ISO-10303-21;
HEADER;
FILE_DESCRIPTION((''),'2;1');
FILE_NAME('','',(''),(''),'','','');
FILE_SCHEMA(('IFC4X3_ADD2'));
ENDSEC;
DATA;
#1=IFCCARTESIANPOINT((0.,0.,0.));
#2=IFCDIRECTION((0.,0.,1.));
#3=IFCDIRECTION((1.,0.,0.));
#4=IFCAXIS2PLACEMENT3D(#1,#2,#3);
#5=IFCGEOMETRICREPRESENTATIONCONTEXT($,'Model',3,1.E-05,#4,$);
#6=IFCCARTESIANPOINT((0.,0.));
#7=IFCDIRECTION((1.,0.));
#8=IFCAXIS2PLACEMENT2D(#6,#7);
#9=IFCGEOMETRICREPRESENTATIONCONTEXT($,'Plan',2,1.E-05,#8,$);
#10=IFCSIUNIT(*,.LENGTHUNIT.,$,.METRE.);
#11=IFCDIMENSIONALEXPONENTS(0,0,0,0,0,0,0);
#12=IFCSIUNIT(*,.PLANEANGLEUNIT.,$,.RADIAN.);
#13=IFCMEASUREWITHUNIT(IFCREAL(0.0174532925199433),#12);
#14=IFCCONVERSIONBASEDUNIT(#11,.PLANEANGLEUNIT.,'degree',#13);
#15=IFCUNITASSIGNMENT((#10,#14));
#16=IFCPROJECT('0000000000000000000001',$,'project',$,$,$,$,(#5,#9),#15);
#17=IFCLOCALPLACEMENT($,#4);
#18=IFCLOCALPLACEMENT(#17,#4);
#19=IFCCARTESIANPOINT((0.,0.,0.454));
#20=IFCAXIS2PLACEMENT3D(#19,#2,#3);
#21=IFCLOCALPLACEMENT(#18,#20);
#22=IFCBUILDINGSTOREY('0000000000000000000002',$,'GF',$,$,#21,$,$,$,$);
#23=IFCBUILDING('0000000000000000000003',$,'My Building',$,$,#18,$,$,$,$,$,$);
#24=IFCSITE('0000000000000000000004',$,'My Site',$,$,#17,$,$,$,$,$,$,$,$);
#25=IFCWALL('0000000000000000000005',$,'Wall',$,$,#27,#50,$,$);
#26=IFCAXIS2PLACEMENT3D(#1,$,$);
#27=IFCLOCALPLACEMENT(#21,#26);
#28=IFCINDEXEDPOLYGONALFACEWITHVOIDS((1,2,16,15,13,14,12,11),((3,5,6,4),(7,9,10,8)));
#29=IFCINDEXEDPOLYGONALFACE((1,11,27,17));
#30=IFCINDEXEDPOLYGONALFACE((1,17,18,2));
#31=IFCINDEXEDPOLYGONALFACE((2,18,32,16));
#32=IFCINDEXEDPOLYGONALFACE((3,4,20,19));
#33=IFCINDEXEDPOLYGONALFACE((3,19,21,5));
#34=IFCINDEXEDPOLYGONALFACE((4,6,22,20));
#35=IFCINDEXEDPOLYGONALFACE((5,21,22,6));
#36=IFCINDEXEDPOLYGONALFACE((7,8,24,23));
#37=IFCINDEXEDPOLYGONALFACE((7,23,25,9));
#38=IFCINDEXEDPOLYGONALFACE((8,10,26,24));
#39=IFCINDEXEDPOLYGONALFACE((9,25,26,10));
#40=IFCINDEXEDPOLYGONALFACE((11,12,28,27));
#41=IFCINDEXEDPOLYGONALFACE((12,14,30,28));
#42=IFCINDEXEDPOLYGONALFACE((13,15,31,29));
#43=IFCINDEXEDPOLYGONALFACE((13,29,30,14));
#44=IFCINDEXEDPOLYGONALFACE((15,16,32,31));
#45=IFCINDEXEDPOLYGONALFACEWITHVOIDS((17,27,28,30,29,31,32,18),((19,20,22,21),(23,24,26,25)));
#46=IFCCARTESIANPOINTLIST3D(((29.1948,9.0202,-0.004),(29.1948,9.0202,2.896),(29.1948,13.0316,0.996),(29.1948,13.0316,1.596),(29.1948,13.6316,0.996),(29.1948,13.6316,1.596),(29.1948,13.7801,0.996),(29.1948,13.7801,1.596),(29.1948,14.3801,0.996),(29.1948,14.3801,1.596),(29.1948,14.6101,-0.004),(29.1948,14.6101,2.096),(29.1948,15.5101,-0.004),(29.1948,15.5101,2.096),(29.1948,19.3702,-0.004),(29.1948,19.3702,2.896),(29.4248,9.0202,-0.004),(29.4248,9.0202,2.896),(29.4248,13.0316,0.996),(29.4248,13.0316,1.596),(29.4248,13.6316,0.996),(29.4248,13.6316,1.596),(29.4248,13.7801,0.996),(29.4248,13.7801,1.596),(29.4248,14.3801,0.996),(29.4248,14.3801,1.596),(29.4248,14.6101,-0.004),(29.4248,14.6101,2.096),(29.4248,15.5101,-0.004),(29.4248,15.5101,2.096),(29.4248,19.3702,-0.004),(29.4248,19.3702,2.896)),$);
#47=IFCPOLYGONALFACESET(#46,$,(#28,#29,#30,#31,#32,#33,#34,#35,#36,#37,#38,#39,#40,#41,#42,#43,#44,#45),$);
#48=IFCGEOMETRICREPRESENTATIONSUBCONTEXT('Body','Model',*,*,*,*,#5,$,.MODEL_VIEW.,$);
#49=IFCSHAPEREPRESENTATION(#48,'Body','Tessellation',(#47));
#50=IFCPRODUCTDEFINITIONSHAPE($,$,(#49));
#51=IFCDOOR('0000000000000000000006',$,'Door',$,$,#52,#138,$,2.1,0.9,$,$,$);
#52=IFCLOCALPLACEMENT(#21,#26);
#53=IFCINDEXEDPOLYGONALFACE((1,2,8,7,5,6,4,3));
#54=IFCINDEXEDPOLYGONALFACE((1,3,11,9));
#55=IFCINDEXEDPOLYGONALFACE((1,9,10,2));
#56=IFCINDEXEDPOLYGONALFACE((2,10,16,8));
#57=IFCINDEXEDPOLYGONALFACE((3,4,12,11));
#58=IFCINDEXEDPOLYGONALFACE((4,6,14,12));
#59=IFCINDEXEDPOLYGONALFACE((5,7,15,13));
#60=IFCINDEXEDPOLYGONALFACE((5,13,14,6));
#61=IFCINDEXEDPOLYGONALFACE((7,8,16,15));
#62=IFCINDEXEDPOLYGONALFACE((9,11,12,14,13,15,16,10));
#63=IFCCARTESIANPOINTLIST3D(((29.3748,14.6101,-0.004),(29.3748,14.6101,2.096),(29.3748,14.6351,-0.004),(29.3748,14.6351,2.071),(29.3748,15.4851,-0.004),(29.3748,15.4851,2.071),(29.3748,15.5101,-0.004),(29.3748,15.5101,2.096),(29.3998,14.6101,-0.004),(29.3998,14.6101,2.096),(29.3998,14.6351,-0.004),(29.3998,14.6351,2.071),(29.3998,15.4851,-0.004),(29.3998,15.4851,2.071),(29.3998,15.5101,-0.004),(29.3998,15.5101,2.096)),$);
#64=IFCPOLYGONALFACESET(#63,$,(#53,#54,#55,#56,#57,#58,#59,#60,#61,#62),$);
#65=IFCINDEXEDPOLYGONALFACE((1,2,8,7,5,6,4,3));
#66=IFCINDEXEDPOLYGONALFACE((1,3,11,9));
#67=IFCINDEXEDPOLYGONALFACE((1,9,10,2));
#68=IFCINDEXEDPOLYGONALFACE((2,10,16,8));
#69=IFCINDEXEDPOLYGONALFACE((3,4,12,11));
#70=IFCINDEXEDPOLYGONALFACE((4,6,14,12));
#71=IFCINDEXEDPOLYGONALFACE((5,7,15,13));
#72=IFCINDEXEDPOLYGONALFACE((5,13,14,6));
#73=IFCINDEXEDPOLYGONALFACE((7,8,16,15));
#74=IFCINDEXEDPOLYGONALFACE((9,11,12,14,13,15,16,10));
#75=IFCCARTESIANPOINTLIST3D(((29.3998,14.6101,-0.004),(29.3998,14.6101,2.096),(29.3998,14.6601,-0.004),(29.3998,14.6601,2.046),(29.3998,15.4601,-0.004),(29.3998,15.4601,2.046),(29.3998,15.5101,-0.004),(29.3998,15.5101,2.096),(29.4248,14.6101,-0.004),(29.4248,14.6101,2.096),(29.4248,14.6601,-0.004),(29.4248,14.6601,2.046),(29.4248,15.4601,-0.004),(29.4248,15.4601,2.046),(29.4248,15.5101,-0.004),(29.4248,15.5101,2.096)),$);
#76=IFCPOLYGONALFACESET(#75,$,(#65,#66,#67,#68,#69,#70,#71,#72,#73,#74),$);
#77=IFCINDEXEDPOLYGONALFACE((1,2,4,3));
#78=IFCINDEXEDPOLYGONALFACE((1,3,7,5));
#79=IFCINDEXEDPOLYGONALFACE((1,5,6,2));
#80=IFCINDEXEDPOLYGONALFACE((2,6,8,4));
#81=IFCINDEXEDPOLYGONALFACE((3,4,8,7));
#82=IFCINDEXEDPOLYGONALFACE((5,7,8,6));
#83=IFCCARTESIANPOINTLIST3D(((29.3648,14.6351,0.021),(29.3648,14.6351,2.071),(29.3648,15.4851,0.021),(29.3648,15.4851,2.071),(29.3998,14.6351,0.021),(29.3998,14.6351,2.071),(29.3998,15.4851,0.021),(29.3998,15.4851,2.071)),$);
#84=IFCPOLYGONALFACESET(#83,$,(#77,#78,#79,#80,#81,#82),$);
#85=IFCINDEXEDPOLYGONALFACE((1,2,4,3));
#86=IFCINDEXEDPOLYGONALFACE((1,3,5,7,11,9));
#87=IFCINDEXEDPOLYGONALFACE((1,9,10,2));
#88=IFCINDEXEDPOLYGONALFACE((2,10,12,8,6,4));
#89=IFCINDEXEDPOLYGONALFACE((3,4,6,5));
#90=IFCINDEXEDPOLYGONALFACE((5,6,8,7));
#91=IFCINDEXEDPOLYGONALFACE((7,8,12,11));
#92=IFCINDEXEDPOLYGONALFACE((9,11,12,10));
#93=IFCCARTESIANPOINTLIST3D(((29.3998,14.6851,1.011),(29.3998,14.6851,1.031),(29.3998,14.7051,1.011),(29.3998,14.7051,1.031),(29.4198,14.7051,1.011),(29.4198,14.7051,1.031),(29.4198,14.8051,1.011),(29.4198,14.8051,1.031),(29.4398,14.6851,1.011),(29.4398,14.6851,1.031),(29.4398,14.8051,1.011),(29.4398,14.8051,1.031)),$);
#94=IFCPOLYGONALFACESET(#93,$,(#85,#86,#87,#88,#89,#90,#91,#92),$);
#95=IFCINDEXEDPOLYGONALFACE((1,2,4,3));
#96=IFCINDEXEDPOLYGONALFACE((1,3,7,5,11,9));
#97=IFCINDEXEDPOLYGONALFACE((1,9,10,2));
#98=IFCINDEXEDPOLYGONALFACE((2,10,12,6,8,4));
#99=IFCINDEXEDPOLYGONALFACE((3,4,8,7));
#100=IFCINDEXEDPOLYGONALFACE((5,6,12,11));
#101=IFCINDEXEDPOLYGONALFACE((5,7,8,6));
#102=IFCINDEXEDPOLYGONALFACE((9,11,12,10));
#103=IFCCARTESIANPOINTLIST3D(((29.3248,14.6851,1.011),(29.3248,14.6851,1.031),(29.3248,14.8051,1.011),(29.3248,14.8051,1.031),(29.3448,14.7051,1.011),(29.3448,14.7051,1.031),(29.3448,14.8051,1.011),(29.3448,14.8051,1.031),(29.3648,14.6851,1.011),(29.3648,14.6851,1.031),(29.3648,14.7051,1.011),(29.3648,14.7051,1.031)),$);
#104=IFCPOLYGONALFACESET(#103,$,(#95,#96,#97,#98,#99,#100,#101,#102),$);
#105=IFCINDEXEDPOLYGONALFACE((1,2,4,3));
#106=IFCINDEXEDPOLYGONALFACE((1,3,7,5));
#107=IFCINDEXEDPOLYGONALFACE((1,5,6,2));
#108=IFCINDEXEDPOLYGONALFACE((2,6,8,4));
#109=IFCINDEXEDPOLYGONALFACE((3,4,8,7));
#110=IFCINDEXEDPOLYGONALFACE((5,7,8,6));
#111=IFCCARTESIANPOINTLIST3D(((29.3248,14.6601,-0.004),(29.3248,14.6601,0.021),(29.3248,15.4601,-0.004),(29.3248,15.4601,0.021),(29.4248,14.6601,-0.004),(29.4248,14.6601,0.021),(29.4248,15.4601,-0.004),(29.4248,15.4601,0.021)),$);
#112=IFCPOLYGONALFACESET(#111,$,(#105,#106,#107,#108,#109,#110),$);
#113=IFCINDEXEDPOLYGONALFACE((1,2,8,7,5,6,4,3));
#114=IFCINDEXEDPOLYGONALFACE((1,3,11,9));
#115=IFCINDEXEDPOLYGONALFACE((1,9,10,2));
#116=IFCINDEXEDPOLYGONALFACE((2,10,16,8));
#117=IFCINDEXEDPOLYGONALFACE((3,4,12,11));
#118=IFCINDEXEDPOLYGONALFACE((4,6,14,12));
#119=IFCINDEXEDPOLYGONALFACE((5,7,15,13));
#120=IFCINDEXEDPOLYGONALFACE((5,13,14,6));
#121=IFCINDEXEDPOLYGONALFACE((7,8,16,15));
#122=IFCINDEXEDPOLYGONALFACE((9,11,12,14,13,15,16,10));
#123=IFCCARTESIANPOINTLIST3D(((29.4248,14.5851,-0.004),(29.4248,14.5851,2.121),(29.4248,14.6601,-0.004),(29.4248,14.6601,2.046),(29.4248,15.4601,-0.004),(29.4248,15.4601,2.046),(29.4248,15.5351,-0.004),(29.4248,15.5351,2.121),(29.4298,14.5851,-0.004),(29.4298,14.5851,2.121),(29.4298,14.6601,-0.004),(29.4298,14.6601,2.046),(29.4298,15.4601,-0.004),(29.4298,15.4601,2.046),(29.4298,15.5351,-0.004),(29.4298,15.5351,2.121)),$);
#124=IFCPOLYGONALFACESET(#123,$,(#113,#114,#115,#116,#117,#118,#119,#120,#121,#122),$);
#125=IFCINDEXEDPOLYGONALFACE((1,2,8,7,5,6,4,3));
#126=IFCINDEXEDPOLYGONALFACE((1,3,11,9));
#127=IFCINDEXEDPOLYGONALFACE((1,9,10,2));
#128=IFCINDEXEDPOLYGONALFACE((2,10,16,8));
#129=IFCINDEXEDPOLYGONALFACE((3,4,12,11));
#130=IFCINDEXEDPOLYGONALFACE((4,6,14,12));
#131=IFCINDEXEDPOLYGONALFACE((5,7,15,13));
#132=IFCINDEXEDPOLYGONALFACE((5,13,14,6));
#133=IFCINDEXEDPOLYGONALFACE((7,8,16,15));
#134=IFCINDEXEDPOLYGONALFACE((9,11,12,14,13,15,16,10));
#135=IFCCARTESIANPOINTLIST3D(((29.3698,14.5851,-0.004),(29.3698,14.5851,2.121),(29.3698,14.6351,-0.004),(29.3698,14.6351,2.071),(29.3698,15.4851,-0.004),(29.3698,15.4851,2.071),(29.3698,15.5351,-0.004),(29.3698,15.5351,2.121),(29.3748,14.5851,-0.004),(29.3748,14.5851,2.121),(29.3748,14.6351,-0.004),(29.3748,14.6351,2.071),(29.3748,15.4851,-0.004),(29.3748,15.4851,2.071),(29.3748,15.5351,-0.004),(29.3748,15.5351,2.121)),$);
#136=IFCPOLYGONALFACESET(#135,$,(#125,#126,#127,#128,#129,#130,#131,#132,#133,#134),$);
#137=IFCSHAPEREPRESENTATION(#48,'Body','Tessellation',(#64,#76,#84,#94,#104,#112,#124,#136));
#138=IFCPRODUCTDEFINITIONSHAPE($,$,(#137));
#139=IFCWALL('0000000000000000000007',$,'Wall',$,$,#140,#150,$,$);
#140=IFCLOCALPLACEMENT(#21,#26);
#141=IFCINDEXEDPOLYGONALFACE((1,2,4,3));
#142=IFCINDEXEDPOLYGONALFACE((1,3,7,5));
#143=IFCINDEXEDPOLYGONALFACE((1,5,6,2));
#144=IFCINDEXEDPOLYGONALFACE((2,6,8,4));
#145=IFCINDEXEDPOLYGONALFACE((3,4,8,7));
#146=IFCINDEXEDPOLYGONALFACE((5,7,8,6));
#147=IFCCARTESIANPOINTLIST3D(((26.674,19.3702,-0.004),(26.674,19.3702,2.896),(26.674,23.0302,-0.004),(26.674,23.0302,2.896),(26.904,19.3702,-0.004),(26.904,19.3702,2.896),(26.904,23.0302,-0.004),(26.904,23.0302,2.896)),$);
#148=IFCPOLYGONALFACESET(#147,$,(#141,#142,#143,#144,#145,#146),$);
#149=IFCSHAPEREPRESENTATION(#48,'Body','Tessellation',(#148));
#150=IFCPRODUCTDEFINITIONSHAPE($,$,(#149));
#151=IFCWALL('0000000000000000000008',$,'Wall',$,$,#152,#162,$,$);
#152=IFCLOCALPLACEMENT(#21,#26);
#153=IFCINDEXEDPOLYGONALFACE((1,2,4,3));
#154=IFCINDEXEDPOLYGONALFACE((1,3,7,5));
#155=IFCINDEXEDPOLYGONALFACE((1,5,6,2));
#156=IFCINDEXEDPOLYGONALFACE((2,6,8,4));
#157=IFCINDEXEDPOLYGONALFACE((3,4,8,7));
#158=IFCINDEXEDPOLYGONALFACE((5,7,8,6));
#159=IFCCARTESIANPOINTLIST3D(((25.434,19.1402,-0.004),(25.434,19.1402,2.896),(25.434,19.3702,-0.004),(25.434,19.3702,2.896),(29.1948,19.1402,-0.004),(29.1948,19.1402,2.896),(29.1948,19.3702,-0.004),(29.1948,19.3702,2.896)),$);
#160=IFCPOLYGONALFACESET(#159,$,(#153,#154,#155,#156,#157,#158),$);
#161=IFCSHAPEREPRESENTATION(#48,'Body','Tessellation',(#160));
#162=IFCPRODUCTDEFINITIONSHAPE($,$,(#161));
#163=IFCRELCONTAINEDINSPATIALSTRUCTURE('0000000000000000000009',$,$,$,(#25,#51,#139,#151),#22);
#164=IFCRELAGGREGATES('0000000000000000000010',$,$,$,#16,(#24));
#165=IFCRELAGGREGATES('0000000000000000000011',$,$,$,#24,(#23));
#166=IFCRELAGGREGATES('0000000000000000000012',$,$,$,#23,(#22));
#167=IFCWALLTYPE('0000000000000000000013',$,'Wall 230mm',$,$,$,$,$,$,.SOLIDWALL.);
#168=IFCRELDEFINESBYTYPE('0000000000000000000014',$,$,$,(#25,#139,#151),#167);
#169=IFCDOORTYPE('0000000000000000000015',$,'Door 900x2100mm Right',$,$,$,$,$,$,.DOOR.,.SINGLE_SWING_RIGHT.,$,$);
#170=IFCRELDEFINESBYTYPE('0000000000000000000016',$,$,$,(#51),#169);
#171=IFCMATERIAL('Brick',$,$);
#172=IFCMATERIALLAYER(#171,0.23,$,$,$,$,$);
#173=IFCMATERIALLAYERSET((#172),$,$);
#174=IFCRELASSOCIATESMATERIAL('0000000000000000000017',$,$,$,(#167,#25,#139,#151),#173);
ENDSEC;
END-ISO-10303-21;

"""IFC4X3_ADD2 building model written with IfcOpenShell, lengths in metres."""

from ifc_helpers import new_model, entity, si_unit, converted_unit, frame, origin_with_axes, origin_2d_with_axis, place, context, subcontext, project, spatial, line, indexed_curve, outline, extrude, shape, source, transform, mapped, material, layer, layer_set, layer_usage, type_object, type_shapes, element, fill, save


model = new_model("IFC4X3_ADD2")

# Units and contexts
model_context = context("Model", 3, precision=1e-05, world=origin_with_axes())
plan_context = context("Plan", 2, precision=1e-05, world=origin_2d_with_axis())
body_context_1 = subcontext(model_context, "Body", "Model", "MODEL_VIEW")
body_context_2 = subcontext(plan_context, "Body", "Plan", "PLAN_VIEW")
ifc_project = project(units=[si_unit("LENGTHUNIT", "METRE"), converted_unit("PLANEANGLEUNIT", "degree", entity("IfcReal", 0.0174532925199433), si_unit("PLANEANGLEUNIT", "RADIAN"), dimensions=[0, 0, 0, 0, 0, 0, 0])], contexts=[model_context, plan_context])

# Site, building, storey
site_placement = place(None, origin_with_axes())
site = spatial("IfcSite", under=ifc_project, at=site_placement, Name="My Site")
building_placement = place(site_placement, origin_with_axes())
building = spatial("IfcBuilding", under=site, at=building_placement, Name="My Building")
storey_placement = place(building_placement, frame((0.0, 0.0, 0.454), z_axis=(0.0, 0.0, 1.0), x_axis=(1.0, 0.0, 0.0)))
storey = spatial("IfcBuildingStorey", under=building, at=storey_placement, Name="GF")

# Shared definitions
ifc_material_1 = material(Name="Brick")

# Shared definitions
ifc_layer_1 = layer(ifc_material_1, 0.23)
ifc_layer_set_1 = layer_set([ifc_layer_1])
wall_type_1 = type_object("IfcWallType", Name="Wall 230mm", PredefinedType="SOLIDWALL", material=ifc_layer_set_1)

# Wall, openings, door
ifc_layer_usage_1 = layer_usage(ifc_layer_set_1, "AXIS2", "POSITIVE", 0.0)
wall_1_placement = place(storey_placement, frame((29.4248, 9.0202, -0.004), z_axis=(0.0, 0.0, 1.0), x_axis=(0.000001, 1.0, 0.0)))
wall_1 = element("IfcWall", 1, at=wall_1_placement, inside=storey, type_object=wall_type_1, material=ifc_layer_usage_1, Name="Wall", context=body_context_1, shape_type="SweptSolid", body=[
    extrude(outline(indexed_curve([(0.0, 0.0), (0.0, 0.23), (10.35, 0.23), (10.35, 0.0), (0.0, 0.0)], self_intersect=False)), origin_with_axes(), (0.0, 0.0, 1.0), 2.9),
])
shared_shape_1 = source(origin_with_axes(), body_context_1, "Body", "SweptSolid", [
    extrude(outline(indexed_curve([(0.0, 0.0), (0.9, 0.0), (0.9, 2.1), (0.0, 2.1)], segments=[line(1, 2, 3, 4, 1)])), frame((0.0, -0.6, 0.0), z_axis=(0.0, -1.0, 0.0), x_axis=(1.0, 0.0, 0.0)), (0.0, 0.0, -1.0), 1.2),
])
opening_1_placement = place(wall_1_placement, frame((5.5899, 0.0, 0.0), z_axis=(0.0, 0.0, 1.0), x_axis=(1.0, 0.0, 0.0)))
opening_1 = element("IfcOpeningElement", 2, at=opening_1_placement, cuts=wall_1, PredefinedType="OPENING", context=body_context_1, shape_type="MappedRepresentation", body=[
    mapped(shared_shape_1, transform((0.0, 0.0, 0.0), x_axis=(1.0, 0.0, 0.0), y_axis=(0.0, 1.0, 0.0), z_axis=(0.0, 0.0, 1.0), scale=1.0)),
])
shared_shape_2 = source(origin_with_axes(), body_context_1, "Body", "SweptSolid", [
    extrude(outline(indexed_curve([(0.0, 0.0), (0.6, 0.0), (0.6, 0.6), (0.0, 0.6)], segments=[line(1, 2, 3, 4, 1)])), frame((-0.3, -0.6, 0.0), z_axis=(0.0, -1.0, 0.0), x_axis=(1.0, 0.0, 0.0)), (0.0, 0.0, -1.0), 1.2),
])
opening_2_placement = place(wall_1_placement, frame((5.0599, 0.0, 1.0), z_axis=(0.0, 0.0, 1.0), x_axis=(1.0, 0.0, 0.0)))
element("IfcOpeningElement", 3, at=opening_2_placement, cuts=wall_1, PredefinedType="OPENING", context=body_context_1, shape_type="MappedRepresentation", body=[
    mapped(shared_shape_2, transform((0.0, 0.0, 0.0), x_axis=(1.0, 0.0, 0.0), y_axis=(0.0, 1.0, 0.0), z_axis=(0.0, 0.0, 1.0), scale=1.0)),
])
opening_3_placement = place(wall_1_placement, frame((4.3114, 0.0, 1.0), z_axis=(0.0, 0.0, 1.0), x_axis=(1.0, 0.0, 0.0)))
element("IfcOpeningElement", 4, at=opening_3_placement, cuts=wall_1, PredefinedType="OPENING", context=body_context_1, shape_type="MappedRepresentation", body=[
    mapped(shared_shape_2, transform((0.0, 0.0, 0.0), x_axis=(1.0, 0.0, 0.0), y_axis=(0.0, 1.0, 0.0), z_axis=(0.0, 0.0, 1.0), scale=1.0)),
])
door_type_1 = type_object("IfcDoorType", Name="Door 900x2100mm Right", OperationType="SINGLE_SWING_RIGHT", PredefinedType="DOOR")
shared_shape_3 = source(origin_with_axes(), body_context_1, "Body", "SweptSolid", [
    extrude(outline(indexed_curve([(0.0, 0.0), (0.0, 2.1), (0.9, 2.1), (0.9, 0.0), (0.875, 0.0), (0.875, 2.075), (0.025, 2.075), (0.025, 0.0)], segments=[line(1, 2, 3, 4, 5, 6, 7, 8, 1)])), frame((0.0, 0.025, 0.0), z_axis=(0.0, -1.0, 0.0), x_axis=(1.0, 0.0, 0.0)), (0.0, 0.0, -1.0), 0.025),
    extrude(outline(indexed_curve([(0.0, 0.0), (0.0, 2.1), (0.9, 2.1), (0.9, 0.0), (0.85, 0.0), (0.85, 2.05), (0.05, 2.05), (0.05, 0.0)], segments=[line(1, 2, 3, 4, 5, 6, 7, 8, 1)])), frame((0.0, 0.0, 0.0), z_axis=(0.0, -1.0, 0.0), x_axis=(1.0, 0.0, 0.0)), (0.0, 0.0, -1.0), 0.025),
    extrude(outline(indexed_curve([(0.0, 0.0), (0.85, 0.0), (0.85, 0.035), (0.0, 0.035)], segments=[line(1, 2, 3, 4, 1)])), frame((0.025, 0.025, 0.025), z_axis=(0.0, 0.0, 1.0), x_axis=(1.0, 0.0, 0.0)), (0.0, 0.0, 1.0), 2.05),
    extrude(outline(indexed_curve([(0.0, 0.0), (0.0, -0.04), (0.12, -0.04), (0.12, -0.02), (0.02, -0.02), (0.02, 0.0)], segments=[line(1, 2, 3, 4, 5, 6, 1)])), frame((0.075, 0.025, 1.015), z_axis=(0.0, 0.0, 1.0), x_axis=(1.0, 0.0, 0.0)), (0.0, 0.0, 1.0), 0.02),
    extrude(outline(indexed_curve([(0.0, 0.0), (0.0, 0.04), (0.12, 0.04), (0.12, 0.02), (0.02, 0.02), (0.02, 0.0)], segments=[line(1, 2, 3, 4, 5, 6, 1)])), frame((0.075, 0.06, 1.015), z_axis=(0.0, 0.0, 1.0), x_axis=(1.0, 0.0, 0.0)), (0.0, 0.0, 1.0), 0.02),
    extrude(outline(indexed_curve([(0.0, 0.0), (0.8, 0.0), (0.8, 0.1), (0.0, 0.1)], segments=[line(1, 2, 3, 4, 1)])), frame((0.05, 0.0, 0.0), z_axis=(0.0, 0.0, 1.0), x_axis=(1.0, 0.0, 0.0)), (0.0, 0.0, 1.0), 0.025),
    extrude(outline(indexed_curve([(0.0, 0.0), (0.0, 2.125), (0.95, 2.125), (0.95, 0.0), (0.875, 0.0), (0.875, 2.05), (0.075, 2.05), (0.075, 0.0)], segments=[line(1, 2, 3, 4, 5, 6, 7, 8, 1)])), frame((-0.025, -0.005, 0.0), z_axis=(0.0, -1.0, 0.0), x_axis=(1.0, 0.0, 0.0)), (0.0, 0.0, -1.0), 0.005),
    extrude(outline(indexed_curve([(0.0, 0.0), (0.0, 2.125), (0.95, 2.125), (0.95, 0.0), (0.9, 0.0), (0.9, 2.075), (0.05, 2.075), (0.05, 0.0)], segments=[line(1, 2, 3, 4, 5, 6, 7, 8, 1)])), frame((-0.025, 0.05, 0.0), z_axis=(0.0, -1.0, 0.0), x_axis=(1.0, 0.0, 0.0)), (0.0, 0.0, -1.0), 0.005),
])
shared_shape_4 = source(origin_with_axes(), body_context_2, "Body", "Curve2D", [
    entity("IfcIndexedPolyCurve", entity("IfcCartesianPointList2D", [[0.0, 0.0], [0.0, 0.05], [0.025, 0.05], [0.025, 0.025], [0.05, 0.025], [0.05, 0.0]]), [entity("IfcLineIndex", [1, 2, 3, 4, 5, 6, 1])]),
    entity("IfcIndexedPolyCurve", entity("IfcCartesianPointList2D", [[0.9, 0.0], [0.9, 0.05], [0.875, 0.05], [0.875, 0.025], [0.85, 0.025], [0.85, 0.0]]), [entity("IfcLineIndex", [1, 2, 3, 4, 5, 6, 1])]),
    entity("IfcTrimmedCurve", entity("IfcEllipse", entity("IfcAxis2Placement2D", entity("IfcCartesianPoint", [0.84, 0.05]), entity("IfcDirection", [1.0, 0.0])), 0.815, 0.85), [entity("IfcCartesianPoint", [0.84, 0.9])], [entity("IfcCartesianPoint", [0.025, 0.05])], True, "CARTESIAN"),
    entity("IfcIndexedPolyCurve", entity("IfcCartesianPointList2D", [[0.875, 0.05], [0.84, 0.05], [0.84, 0.9], [0.875, 0.9]]), [entity("IfcLineIndex", [1, 2, 3, 4, 1])]),
])
type_shapes(door_type_1, [shared_shape_3, shared_shape_4])
door_1_placement = place(opening_1_placement, frame((0.0, 0.0, 0.0), z_axis=(0.0, 0.0, 1.0), x_axis=(1.0, 0.0, 0.0)))
door_1 = element("IfcDoor", 5, at=door_1_placement, inside=storey, type_object=door_type_1, Name="Door", OverallHeight=2.1, OverallWidth=0.9, shapes=[
    shape(body_context_1, "Body", "MappedRepresentation", [mapped(shared_shape_3, transform((0.0, 0.0, 0.0), x_axis=(1.0, 0.0, 0.0), y_axis=(0.0, 1.0, 0.0), z_axis=(0.0, 0.0, 1.0), scale=1.0))]),
    shape(body_context_2, "Body", "MappedRepresentation", [mapped(shared_shape_4, transform((0.0, 0.0, 0.0), x_axis=(1.0, 0.0, 0.0), y_axis=(0.0, 1.0, 0.0), z_axis=(0.0, 0.0, 1.0), scale=1.0))]),
])
fill(opening_1, door_1)

# Walls
ifc_layer_usage_2 = layer_usage(ifc_layer_set_1, "AXIS2", "POSITIVE", 0.0)
wall_2_placement = place(storey_placement, frame((26.904, 19.3702, -0.004), z_axis=(0.0, 0.0, 1.0), x_axis=(0.000001, 1.0, 0.0)))
element("IfcWall", 6, at=wall_2_placement, inside=storey, type_object=wall_type_1, material=ifc_layer_usage_2, Name="Wall", context=body_context_1, shape_type="SweptSolid", body=[
    extrude(outline(indexed_curve([(0.0, 0.0), (0.0, 0.23), (3.66, 0.23), (3.66, 0.0), (0.0, 0.0)], self_intersect=False)), origin_with_axes(), (0.0, 0.0, 1.0), 2.9),
])
ifc_layer_usage_3 = layer_usage(ifc_layer_set_1, "AXIS2", "POSITIVE", 0.0)
wall_3_placement = place(storey_placement, frame((29.1948, 19.3702, -0.004), z_axis=(0.0, 0.0, 1.0), x_axis=(-1.0, 0.0, 0.0)))
element("IfcWall", 7, at=wall_3_placement, inside=storey, type_object=wall_type_1, material=ifc_layer_usage_3, Name="Wall", context=body_context_1, shape_type="SweptSolid", body=[
    extrude(outline(indexed_curve([(0.0, 0.0), (0.0, 0.23), (3.7608, 0.23), (3.7608, 0.0), (0.0, 0.0)], self_intersect=False)), origin_with_axes(), (0.0, 0.0, 1.0), 2.9),
])

save(model, "model.ifc")
